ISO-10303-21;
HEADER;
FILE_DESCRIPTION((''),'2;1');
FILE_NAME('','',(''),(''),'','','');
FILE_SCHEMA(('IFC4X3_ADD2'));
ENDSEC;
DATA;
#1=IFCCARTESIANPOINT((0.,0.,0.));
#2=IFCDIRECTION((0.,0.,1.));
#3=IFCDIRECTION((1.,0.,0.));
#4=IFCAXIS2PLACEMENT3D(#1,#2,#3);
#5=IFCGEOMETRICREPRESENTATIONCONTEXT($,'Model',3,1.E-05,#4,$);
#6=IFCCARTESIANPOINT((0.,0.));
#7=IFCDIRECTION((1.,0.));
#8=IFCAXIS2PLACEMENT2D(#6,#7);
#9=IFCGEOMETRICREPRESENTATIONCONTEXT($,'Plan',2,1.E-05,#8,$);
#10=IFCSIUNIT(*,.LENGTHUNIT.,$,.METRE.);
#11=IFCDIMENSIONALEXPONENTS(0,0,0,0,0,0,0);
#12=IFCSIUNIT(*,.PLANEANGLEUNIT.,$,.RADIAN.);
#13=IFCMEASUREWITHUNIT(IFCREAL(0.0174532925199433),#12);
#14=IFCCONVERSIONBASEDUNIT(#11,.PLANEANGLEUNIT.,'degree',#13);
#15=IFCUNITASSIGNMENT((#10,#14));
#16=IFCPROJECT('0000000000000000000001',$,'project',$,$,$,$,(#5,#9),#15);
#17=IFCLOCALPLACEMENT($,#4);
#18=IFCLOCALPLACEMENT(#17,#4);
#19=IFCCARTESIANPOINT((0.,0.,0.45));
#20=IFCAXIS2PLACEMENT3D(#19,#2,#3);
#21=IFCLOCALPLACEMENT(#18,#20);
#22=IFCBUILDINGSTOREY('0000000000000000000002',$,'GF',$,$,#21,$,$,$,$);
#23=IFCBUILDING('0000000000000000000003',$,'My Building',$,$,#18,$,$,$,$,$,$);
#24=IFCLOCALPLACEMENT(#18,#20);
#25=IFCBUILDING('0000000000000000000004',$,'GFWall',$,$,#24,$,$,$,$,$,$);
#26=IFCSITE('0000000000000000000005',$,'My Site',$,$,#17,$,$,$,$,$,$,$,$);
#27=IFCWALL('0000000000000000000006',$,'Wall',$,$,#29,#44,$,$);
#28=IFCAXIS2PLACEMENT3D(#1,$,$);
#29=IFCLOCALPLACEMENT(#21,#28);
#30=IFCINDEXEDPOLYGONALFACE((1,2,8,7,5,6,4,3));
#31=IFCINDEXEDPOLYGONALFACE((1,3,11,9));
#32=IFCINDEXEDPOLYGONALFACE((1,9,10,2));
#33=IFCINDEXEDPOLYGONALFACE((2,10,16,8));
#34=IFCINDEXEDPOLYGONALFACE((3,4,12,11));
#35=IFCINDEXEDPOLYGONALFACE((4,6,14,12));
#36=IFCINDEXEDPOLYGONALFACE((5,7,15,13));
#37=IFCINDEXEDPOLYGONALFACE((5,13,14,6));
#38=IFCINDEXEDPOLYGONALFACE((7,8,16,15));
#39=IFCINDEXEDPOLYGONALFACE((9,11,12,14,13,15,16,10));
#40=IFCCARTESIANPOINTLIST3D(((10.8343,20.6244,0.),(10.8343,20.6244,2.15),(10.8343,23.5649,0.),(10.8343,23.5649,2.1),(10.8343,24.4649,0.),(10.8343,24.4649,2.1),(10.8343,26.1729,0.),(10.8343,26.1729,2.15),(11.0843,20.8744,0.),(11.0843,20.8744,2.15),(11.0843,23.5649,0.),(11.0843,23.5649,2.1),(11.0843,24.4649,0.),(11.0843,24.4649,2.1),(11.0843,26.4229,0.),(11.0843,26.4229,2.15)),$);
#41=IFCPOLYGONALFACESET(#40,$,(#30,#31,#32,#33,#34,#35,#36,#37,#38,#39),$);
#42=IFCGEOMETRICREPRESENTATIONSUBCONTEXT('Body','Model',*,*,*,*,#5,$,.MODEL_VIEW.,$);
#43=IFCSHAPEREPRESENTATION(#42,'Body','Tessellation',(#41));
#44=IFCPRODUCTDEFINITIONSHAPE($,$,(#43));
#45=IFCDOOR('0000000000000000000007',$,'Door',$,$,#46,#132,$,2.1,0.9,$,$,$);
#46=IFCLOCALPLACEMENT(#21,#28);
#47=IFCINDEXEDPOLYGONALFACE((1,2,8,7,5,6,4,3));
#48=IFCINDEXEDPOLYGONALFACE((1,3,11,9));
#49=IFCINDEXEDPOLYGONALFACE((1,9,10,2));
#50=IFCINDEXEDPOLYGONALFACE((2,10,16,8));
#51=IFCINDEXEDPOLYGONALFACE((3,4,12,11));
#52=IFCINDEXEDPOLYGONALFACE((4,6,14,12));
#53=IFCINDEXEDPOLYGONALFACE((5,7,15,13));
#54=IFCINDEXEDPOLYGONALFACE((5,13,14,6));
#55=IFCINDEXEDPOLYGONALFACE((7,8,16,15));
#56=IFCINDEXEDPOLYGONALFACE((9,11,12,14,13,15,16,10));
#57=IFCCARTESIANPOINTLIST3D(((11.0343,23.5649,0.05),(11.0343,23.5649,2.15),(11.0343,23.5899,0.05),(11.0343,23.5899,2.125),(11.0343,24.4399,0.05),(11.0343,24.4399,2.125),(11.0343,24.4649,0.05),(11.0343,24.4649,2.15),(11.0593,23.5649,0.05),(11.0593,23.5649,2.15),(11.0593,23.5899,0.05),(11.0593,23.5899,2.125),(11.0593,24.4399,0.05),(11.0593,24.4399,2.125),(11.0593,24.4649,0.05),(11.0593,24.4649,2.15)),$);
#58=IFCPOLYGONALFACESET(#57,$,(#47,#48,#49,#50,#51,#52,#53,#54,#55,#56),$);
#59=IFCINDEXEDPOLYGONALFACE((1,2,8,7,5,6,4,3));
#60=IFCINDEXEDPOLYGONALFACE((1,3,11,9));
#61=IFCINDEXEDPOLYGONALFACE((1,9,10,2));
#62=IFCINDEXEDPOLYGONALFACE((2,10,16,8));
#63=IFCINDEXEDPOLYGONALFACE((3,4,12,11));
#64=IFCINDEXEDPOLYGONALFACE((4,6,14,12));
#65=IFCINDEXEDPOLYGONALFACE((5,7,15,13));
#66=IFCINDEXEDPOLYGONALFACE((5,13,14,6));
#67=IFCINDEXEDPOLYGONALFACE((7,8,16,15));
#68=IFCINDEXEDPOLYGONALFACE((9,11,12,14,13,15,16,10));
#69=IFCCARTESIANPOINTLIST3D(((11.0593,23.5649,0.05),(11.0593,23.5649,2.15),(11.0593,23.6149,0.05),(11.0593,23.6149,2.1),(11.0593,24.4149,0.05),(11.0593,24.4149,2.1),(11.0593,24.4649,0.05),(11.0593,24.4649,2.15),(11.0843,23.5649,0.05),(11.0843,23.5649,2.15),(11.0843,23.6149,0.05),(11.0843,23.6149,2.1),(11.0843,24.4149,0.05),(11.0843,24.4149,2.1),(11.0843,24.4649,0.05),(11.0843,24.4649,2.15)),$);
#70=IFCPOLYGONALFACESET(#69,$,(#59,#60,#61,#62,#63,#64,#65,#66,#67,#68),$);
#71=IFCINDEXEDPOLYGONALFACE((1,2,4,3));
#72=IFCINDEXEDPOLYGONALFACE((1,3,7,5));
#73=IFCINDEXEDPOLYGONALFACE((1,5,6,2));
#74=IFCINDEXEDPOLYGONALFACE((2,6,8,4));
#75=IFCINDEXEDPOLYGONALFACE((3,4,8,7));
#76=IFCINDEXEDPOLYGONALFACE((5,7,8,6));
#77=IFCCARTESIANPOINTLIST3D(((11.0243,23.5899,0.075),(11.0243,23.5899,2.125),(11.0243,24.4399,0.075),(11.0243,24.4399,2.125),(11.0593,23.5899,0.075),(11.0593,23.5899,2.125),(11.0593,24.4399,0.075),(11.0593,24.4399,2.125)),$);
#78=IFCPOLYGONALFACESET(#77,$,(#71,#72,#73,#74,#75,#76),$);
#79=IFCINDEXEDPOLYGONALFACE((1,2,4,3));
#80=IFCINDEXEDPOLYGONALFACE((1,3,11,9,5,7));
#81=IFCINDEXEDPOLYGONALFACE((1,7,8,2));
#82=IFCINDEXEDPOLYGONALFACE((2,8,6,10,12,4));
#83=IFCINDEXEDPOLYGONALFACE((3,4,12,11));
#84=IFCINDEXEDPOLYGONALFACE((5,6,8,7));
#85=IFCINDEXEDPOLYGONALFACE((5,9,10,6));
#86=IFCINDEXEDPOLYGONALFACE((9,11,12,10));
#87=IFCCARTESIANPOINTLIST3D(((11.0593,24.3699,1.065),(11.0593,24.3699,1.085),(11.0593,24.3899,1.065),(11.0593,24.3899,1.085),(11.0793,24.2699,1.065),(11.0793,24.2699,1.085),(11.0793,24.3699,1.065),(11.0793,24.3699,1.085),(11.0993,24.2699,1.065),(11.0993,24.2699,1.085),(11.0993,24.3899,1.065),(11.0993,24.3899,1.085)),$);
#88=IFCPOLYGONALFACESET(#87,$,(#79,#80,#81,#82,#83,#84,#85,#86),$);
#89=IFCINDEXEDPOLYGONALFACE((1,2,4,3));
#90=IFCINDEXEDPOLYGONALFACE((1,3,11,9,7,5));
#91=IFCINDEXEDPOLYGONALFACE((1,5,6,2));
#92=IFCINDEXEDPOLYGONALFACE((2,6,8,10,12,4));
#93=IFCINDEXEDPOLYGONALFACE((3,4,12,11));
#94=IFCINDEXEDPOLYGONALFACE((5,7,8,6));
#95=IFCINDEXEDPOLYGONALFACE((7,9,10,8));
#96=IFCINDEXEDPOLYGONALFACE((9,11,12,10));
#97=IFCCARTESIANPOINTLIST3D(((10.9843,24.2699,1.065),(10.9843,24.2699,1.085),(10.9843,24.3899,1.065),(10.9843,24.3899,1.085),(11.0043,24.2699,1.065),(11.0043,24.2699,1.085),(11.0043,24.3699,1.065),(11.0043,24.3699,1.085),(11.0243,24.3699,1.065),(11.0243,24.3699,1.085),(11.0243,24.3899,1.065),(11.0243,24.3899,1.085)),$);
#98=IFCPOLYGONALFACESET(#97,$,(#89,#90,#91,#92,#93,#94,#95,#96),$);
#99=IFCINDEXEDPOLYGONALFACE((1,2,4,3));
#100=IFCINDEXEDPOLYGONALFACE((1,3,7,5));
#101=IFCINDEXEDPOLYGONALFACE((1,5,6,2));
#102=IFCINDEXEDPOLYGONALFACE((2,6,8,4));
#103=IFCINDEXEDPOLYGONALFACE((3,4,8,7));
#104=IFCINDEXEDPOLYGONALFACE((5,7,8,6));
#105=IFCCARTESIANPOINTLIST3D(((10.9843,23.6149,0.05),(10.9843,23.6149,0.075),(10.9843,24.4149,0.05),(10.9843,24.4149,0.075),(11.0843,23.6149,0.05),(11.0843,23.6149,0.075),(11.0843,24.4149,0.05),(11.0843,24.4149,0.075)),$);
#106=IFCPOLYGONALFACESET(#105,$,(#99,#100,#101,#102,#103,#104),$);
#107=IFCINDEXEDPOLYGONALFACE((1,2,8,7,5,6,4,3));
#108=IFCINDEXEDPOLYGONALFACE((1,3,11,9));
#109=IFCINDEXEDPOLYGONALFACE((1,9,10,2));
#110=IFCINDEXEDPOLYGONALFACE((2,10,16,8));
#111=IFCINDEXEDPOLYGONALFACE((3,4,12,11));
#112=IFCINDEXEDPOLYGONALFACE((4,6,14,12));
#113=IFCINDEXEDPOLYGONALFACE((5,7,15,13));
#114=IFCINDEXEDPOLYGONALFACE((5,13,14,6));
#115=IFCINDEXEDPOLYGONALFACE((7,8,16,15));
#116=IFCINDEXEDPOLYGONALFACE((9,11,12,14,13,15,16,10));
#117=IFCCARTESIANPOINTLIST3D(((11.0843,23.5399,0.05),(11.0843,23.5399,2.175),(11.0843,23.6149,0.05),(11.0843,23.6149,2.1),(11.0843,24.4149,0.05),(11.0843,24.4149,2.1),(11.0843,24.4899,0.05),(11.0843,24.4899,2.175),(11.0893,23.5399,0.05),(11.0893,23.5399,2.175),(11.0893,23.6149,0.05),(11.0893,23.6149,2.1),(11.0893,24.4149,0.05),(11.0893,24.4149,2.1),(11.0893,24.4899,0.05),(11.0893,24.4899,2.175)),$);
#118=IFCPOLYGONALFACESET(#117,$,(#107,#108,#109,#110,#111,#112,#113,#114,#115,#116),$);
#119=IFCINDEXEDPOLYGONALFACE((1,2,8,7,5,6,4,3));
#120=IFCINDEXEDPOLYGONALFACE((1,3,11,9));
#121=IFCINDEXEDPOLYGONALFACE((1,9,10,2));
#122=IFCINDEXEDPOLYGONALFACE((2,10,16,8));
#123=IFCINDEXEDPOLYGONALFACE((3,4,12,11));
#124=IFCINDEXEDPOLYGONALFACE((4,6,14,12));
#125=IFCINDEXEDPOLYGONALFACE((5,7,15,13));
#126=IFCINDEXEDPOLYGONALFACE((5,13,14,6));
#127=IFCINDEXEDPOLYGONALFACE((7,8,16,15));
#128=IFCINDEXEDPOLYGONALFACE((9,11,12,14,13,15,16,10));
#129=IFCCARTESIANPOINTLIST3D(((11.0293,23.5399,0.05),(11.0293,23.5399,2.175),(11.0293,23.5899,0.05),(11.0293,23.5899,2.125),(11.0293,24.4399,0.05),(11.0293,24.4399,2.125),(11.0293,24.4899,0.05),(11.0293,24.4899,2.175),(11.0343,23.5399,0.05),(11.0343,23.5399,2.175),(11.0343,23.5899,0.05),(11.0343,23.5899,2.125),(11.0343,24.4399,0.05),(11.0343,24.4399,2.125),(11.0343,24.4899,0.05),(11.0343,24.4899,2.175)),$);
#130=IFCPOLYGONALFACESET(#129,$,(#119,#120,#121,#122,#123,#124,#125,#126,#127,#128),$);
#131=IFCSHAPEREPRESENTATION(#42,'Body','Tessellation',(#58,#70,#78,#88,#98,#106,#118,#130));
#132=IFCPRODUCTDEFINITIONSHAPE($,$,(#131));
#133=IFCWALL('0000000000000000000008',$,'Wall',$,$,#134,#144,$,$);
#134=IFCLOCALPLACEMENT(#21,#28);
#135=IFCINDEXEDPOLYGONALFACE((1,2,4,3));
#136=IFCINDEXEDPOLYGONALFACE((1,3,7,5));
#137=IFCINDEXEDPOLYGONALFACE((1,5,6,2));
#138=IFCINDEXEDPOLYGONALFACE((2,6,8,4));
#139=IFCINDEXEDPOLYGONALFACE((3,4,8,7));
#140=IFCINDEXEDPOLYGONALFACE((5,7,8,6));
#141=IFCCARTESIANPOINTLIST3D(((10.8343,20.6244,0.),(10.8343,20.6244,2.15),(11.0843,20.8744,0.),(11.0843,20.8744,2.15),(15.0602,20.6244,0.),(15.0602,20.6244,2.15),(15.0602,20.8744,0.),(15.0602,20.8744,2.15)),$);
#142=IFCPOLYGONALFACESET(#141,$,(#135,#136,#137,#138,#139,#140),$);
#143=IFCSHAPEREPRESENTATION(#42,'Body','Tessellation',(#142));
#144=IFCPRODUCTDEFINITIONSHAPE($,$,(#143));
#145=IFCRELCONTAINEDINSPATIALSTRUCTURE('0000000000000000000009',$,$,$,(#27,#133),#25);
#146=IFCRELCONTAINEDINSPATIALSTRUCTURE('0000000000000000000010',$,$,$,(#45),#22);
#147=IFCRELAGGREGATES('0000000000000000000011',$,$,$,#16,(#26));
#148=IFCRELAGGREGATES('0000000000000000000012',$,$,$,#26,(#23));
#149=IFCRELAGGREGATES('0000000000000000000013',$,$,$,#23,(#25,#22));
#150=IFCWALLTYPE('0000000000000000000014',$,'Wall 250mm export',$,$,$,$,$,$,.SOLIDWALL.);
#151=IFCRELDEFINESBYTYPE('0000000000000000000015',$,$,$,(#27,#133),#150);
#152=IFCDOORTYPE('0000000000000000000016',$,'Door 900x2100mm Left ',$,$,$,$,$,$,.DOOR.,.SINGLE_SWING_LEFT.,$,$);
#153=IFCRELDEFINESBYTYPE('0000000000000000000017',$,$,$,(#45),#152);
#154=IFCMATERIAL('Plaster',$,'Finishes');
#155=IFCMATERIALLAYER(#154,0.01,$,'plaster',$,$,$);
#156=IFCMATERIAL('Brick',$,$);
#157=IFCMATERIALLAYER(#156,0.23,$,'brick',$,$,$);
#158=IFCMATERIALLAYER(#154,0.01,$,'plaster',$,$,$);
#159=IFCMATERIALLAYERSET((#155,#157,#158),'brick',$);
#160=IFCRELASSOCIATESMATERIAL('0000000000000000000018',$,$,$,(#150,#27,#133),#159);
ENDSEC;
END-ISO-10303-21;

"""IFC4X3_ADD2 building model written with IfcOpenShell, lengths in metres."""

from ifc_helpers import new_model, entity, si_unit, converted_unit, frame, origin_with_axes, origin_2d_with_axis, place, context, subcontext, project, spatial, line, indexed_curve, outline, extrude, shape, source, transform, mapped, material, layer, layer_set, layer_usage, type_object, type_shapes, element, fill, save


model = new_model("IFC4X3_ADD2")

# Units and contexts
model_context = context("Model", 3, precision=1e-05, world=origin_with_axes())
plan_context = context("Plan", 2, precision=1e-05, world=origin_2d_with_axis())
body_context_1 = subcontext(model_context, "Body", "Model", "MODEL_VIEW")
body_context_2 = subcontext(plan_context, "Body", "Plan", "PLAN_VIEW")
ifc_project = project(units=[si_unit("LENGTHUNIT", "METRE"), converted_unit("PLANEANGLEUNIT", "degree", entity("IfcReal", 0.0174532925199433), si_unit("PLANEANGLEUNIT", "RADIAN"), dimensions=[0, 0, 0, 0, 0, 0, 0])], contexts=[model_context, plan_context])

# Site, buildings
site_placement = place(None, origin_with_axes())
site = spatial("IfcSite", under=ifc_project, at=site_placement, Name="My Site")
building_1_placement = place(site_placement, origin_with_axes())
building_1 = spatial("IfcBuilding", under=site, at=building_1_placement, Name="My Building")
building_2_placement = place(building_1_placement, frame((0.0, 0.0, 0.45), z_axis=(0.0, 0.0, 1.0), x_axis=(1.0, 0.0, 0.0)))
building_2 = spatial("IfcBuilding", under=building_1, at=building_2_placement, Name="GFWall")

# Shared definitions
ifc_material_1 = material(Name="Plaster", Category="Finishes")

# Shared definitions
storey_placement = place(building_1_placement, frame((0.0, 0.0, 0.45), z_axis=(0.0, 0.0, 1.0), x_axis=(1.0, 0.0, 0.0)))
storey = spatial("IfcBuildingStorey", under=building_1, at=storey_placement, Name="GF")

# Shared definitions
ifc_layer_1 = layer(ifc_material_1, 0.01, Name="plaster")
ifc_material_2 = material(Name="Brick")
ifc_layer_2 = layer(ifc_material_2, 0.23, Name="brick")
ifc_layer_3 = layer(ifc_material_1, 0.01, Name="plaster")
ifc_layer_set_1 = layer_set([ifc_layer_1, ifc_layer_2, ifc_layer_3], Name="brick")
wall_type_1 = type_object("IfcWallType", Name="Wall 250mm export", PredefinedType="SOLIDWALL", material=ifc_layer_set_1)

# Wall, opening, door
ifc_layer_usage_1 = layer_usage(ifc_layer_set_1, "AXIS2", "POSITIVE", 0.0)
wall_1_placement = place(building_2_placement, frame((11.0843, 20.6244, 0.0), z_axis=(0.0, 0.0, 1.0), x_axis=(0.0, 1.0, 0.0)))
wall_1 = element("IfcWall", 1, at=wall_1_placement, inside=building_2, type_object=wall_type_1, material=ifc_layer_usage_1, Name="Wall", context=body_context_1, shape_type="SweptSolid", body=[
    extrude(outline(indexed_curve([(0.25, 0.0), (0.0, 0.25), (5.5485, 0.25), (5.7985, 0.0)], segments=[line(1, 2, 3, 4, 1)])), origin_with_axes(), (0.0, 0.0, 1.0), 2.15),
])
shared_shape_1 = source(origin_with_axes(), body_context_1, "Body", "SweptSolid", [
    extrude(outline(indexed_curve([(0.0, 0.0), (0.9, 0.0), (0.9, 2.1), (0.0, 2.1)], segments=[line(1, 2, 3, 4, 1)])), frame((0.0, -0.6, 0.0), z_axis=(0.0, -1.0, 0.0), x_axis=(1.0, 0.0, 0.0)), (0.0, 0.0, -1.0), 1.2),
])
opening_1_placement = place(wall_1_placement, frame((2.9405, 0.0, 0.0), z_axis=(0.0, 0.0, 1.0), x_axis=(1.0, 0.0, 0.0)))
opening_1 = element("IfcOpeningElement", 2, at=opening_1_placement, cuts=wall_1, PredefinedType="OPENING", context=body_context_1, shape_type="MappedRepresentation", body=[
    mapped(shared_shape_1, transform((0.0, 0.0, 0.0), x_axis=(1.0, 0.0, 0.0), y_axis=(0.0, 1.0, 0.0), z_axis=(0.0, 0.0, 1.0), scale=1.0)),
])
door_type_1 = type_object("IfcDoorType", Name="Door 900x2100mm Left ", OperationType="SINGLE_SWING_LEFT", PredefinedType="DOOR")
shared_shape_2 = source(origin_with_axes(), body_context_1, "Body", "SweptSolid", [
    extrude(outline(indexed_curve([(0.0, 0.0), (0.0, 2.1), (0.9, 2.1), (0.9, 0.0), (0.875, 0.0), (0.875, 2.075), (0.025, 2.075), (0.025, 0.0)], segments=[line(1, 2, 3, 4, 5, 6, 7, 8, 1)])), frame((0.0, 0.025, 0.0), z_axis=(0.0, -1.0, 0.0), x_axis=(1.0, 0.0, 0.0)), (0.0, 0.0, -1.0), 0.025),
    extrude(outline(indexed_curve([(0.0, 0.0), (0.0, 2.1), (0.9, 2.1), (0.9, 0.0), (0.85, 0.0), (0.85, 2.05), (0.05, 2.05), (0.05, 0.0)], segments=[line(1, 2, 3, 4, 5, 6, 7, 8, 1)])), frame((0.0, 0.0, 0.0), z_axis=(0.0, -1.0, 0.0), x_axis=(1.0, 0.0, 0.0)), (0.0, 0.0, -1.0), 0.025),
    extrude(outline(indexed_curve([(0.0, 0.0), (0.85, 0.0), (0.85, 0.035), (0.0, 0.035)], segments=[line(1, 2, 3, 4, 1)])), frame((0.025, 0.025, 0.025), z_axis=(0.0, 0.0, 1.0), x_axis=(1.0, 0.0, 0.0)), (0.0, 0.0, 1.0), 2.05),
    extrude(outline(indexed_curve([(0.0, 0.0), (0.0, -0.04), (-0.12, -0.04), (-0.12, -0.02), (-0.02, -0.02), (-0.02, 0.0)], segments=[line(1, 2, 3, 4, 5, 6, 1)])), frame((0.825, 0.025, 1.015), z_axis=(0.0, 0.0, 1.0), x_axis=(1.0, 0.0, 0.0)), (0.0, 0.0, 1.0), 0.02),
    extrude(outline(indexed_curve([(0.0, 0.0), (0.0, 0.04), (-0.12, 0.04), (-0.12, 0.02), (-0.02, 0.02), (-0.02, 0.0)], segments=[line(1, 2, 3, 4, 5, 6, 1)])), frame((0.825, 0.06, 1.015), z_axis=(0.0, 0.0, 1.0), x_axis=(1.0, 0.0, 0.0)), (0.0, 0.0, 1.0), 0.02),
    extrude(outline(indexed_curve([(0.0, 0.0), (0.8, 0.0), (0.8, 0.1), (0.0, 0.1)], segments=[line(1, 2, 3, 4, 1)])), frame((0.05, 0.0, 0.0), z_axis=(0.0, 0.0, 1.0), x_axis=(1.0, 0.0, 0.0)), (0.0, 0.0, 1.0), 0.025),
    extrude(outline(indexed_curve([(0.0, 0.0), (0.0, 2.125), (0.95, 2.125), (0.95, 0.0), (0.875, 0.0), (0.875, 2.05), (0.075, 2.05), (0.075, 0.0)], segments=[line(1, 2, 3, 4, 5, 6, 7, 8, 1)])), frame((-0.025, -0.005, 0.0), z_axis=(0.0, -1.0, 0.0), x_axis=(1.0, 0.0, 0.0)), (0.0, 0.0, -1.0), 0.005),
    extrude(outline(indexed_curve([(0.0, 0.0), (0.0, 2.125), (0.95, 2.125), (0.95, 0.0), (0.9, 0.0), (0.9, 2.075), (0.05, 2.075), (0.05, 0.0)], segments=[line(1, 2, 3, 4, 5, 6, 7, 8, 1)])), frame((-0.025, 0.05, 0.0), z_axis=(0.0, -1.0, 0.0), x_axis=(1.0, 0.0, 0.0)), (0.0, 0.0, -1.0), 0.005),
])
shared_shape_3 = source(origin_with_axes(), body_context_2, "Body", "Curve2D", [
    entity("IfcIndexedPolyCurve", entity("IfcCartesianPointList2D", [[0.0, 0.0], [0.0, 0.05], [0.025, 0.05], [0.025, 0.025], [0.05, 0.025], [0.05, 0.0]]), [entity("IfcLineIndex", [1, 2, 3, 4, 5, 6, 1])]),
    entity("IfcIndexedPolyCurve", entity("IfcCartesianPointList2D", [[0.9, 0.0], [0.9, 0.05], [0.875, 0.05], [0.875, 0.025], [0.85, 0.025], [0.85, 0.0]]), [entity("IfcLineIndex", [1, 2, 3, 4, 5, 6, 1])]),
    entity("IfcTrimmedCurve", entity("IfcEllipse", entity("IfcAxis2Placement2D", entity("IfcCartesianPoint", [0.06, 0.05]), entity("IfcDirection", [1.0, 0.0])), 0.815, 0.85), [entity("IfcCartesianPoint", [0.875, 0.05])], [entity("IfcCartesianPoint", [0.06, 0.9])], True, "CARTESIAN"),
    entity("IfcIndexedPolyCurve", entity("IfcCartesianPointList2D", [[0.025, 0.05], [0.06, 0.05], [0.06, 0.9], [0.025, 0.9]]), [entity("IfcLineIndex", [1, 2, 3, 4, 1])]),
])
type_shapes(door_type_1, [shared_shape_2, shared_shape_3])
door_1_placement = place(opening_1_placement, frame((0.0, 0.0, 0.05), z_axis=(0.0, 0.0, 1.0), x_axis=(1.0, 0.0, 0.0)))
door_1 = element("IfcDoor", 3, at=door_1_placement, inside=storey, type_object=door_type_1, Name="Door", OverallHeight=2.1, OverallWidth=0.9, shapes=[
    shape(body_context_1, "Body", "MappedRepresentation", [mapped(shared_shape_2, transform((0.0, 0.0, 0.0), x_axis=(1.0, 0.0, 0.0), y_axis=(0.0, 1.0, 0.0), z_axis=(0.0, 0.0, 1.0), scale=1.0))]),
    shape(body_context_2, "Body", "MappedRepresentation", [mapped(shared_shape_3, transform((0.0, 0.0, 0.0), x_axis=(1.0, 0.0, 0.0), y_axis=(0.0, 1.0, 0.0), z_axis=(0.0, 0.0, 1.0), scale=1.0))]),
])
fill(opening_1, door_1)

# Wall
ifc_layer_usage_2 = layer_usage(ifc_layer_set_1, "AXIS2", "POSITIVE", 0.0)
wall_2_placement = place(building_2_placement, frame((11.0843, 20.6244, 0.0), z_axis=(0.0, 0.0, 1.0), x_axis=(1.0, 0.0, 0.0)))
element("IfcWall", 4, at=wall_2_placement, inside=building_2, type_object=wall_type_1, material=ifc_layer_usage_2, Name="Wall", context=body_context_1, shape_type="SweptSolid", body=[
    extrude(outline(indexed_curve([(-0.25, 0.0), (0.0, 0.25), (3.9759, 0.25), (3.9759, 0.0)], segments=[line(1, 2, 3, 4, 1)])), origin_with_axes(), (0.0, 0.0, 1.0), 2.15),
])

save(model, "model.ifc")
